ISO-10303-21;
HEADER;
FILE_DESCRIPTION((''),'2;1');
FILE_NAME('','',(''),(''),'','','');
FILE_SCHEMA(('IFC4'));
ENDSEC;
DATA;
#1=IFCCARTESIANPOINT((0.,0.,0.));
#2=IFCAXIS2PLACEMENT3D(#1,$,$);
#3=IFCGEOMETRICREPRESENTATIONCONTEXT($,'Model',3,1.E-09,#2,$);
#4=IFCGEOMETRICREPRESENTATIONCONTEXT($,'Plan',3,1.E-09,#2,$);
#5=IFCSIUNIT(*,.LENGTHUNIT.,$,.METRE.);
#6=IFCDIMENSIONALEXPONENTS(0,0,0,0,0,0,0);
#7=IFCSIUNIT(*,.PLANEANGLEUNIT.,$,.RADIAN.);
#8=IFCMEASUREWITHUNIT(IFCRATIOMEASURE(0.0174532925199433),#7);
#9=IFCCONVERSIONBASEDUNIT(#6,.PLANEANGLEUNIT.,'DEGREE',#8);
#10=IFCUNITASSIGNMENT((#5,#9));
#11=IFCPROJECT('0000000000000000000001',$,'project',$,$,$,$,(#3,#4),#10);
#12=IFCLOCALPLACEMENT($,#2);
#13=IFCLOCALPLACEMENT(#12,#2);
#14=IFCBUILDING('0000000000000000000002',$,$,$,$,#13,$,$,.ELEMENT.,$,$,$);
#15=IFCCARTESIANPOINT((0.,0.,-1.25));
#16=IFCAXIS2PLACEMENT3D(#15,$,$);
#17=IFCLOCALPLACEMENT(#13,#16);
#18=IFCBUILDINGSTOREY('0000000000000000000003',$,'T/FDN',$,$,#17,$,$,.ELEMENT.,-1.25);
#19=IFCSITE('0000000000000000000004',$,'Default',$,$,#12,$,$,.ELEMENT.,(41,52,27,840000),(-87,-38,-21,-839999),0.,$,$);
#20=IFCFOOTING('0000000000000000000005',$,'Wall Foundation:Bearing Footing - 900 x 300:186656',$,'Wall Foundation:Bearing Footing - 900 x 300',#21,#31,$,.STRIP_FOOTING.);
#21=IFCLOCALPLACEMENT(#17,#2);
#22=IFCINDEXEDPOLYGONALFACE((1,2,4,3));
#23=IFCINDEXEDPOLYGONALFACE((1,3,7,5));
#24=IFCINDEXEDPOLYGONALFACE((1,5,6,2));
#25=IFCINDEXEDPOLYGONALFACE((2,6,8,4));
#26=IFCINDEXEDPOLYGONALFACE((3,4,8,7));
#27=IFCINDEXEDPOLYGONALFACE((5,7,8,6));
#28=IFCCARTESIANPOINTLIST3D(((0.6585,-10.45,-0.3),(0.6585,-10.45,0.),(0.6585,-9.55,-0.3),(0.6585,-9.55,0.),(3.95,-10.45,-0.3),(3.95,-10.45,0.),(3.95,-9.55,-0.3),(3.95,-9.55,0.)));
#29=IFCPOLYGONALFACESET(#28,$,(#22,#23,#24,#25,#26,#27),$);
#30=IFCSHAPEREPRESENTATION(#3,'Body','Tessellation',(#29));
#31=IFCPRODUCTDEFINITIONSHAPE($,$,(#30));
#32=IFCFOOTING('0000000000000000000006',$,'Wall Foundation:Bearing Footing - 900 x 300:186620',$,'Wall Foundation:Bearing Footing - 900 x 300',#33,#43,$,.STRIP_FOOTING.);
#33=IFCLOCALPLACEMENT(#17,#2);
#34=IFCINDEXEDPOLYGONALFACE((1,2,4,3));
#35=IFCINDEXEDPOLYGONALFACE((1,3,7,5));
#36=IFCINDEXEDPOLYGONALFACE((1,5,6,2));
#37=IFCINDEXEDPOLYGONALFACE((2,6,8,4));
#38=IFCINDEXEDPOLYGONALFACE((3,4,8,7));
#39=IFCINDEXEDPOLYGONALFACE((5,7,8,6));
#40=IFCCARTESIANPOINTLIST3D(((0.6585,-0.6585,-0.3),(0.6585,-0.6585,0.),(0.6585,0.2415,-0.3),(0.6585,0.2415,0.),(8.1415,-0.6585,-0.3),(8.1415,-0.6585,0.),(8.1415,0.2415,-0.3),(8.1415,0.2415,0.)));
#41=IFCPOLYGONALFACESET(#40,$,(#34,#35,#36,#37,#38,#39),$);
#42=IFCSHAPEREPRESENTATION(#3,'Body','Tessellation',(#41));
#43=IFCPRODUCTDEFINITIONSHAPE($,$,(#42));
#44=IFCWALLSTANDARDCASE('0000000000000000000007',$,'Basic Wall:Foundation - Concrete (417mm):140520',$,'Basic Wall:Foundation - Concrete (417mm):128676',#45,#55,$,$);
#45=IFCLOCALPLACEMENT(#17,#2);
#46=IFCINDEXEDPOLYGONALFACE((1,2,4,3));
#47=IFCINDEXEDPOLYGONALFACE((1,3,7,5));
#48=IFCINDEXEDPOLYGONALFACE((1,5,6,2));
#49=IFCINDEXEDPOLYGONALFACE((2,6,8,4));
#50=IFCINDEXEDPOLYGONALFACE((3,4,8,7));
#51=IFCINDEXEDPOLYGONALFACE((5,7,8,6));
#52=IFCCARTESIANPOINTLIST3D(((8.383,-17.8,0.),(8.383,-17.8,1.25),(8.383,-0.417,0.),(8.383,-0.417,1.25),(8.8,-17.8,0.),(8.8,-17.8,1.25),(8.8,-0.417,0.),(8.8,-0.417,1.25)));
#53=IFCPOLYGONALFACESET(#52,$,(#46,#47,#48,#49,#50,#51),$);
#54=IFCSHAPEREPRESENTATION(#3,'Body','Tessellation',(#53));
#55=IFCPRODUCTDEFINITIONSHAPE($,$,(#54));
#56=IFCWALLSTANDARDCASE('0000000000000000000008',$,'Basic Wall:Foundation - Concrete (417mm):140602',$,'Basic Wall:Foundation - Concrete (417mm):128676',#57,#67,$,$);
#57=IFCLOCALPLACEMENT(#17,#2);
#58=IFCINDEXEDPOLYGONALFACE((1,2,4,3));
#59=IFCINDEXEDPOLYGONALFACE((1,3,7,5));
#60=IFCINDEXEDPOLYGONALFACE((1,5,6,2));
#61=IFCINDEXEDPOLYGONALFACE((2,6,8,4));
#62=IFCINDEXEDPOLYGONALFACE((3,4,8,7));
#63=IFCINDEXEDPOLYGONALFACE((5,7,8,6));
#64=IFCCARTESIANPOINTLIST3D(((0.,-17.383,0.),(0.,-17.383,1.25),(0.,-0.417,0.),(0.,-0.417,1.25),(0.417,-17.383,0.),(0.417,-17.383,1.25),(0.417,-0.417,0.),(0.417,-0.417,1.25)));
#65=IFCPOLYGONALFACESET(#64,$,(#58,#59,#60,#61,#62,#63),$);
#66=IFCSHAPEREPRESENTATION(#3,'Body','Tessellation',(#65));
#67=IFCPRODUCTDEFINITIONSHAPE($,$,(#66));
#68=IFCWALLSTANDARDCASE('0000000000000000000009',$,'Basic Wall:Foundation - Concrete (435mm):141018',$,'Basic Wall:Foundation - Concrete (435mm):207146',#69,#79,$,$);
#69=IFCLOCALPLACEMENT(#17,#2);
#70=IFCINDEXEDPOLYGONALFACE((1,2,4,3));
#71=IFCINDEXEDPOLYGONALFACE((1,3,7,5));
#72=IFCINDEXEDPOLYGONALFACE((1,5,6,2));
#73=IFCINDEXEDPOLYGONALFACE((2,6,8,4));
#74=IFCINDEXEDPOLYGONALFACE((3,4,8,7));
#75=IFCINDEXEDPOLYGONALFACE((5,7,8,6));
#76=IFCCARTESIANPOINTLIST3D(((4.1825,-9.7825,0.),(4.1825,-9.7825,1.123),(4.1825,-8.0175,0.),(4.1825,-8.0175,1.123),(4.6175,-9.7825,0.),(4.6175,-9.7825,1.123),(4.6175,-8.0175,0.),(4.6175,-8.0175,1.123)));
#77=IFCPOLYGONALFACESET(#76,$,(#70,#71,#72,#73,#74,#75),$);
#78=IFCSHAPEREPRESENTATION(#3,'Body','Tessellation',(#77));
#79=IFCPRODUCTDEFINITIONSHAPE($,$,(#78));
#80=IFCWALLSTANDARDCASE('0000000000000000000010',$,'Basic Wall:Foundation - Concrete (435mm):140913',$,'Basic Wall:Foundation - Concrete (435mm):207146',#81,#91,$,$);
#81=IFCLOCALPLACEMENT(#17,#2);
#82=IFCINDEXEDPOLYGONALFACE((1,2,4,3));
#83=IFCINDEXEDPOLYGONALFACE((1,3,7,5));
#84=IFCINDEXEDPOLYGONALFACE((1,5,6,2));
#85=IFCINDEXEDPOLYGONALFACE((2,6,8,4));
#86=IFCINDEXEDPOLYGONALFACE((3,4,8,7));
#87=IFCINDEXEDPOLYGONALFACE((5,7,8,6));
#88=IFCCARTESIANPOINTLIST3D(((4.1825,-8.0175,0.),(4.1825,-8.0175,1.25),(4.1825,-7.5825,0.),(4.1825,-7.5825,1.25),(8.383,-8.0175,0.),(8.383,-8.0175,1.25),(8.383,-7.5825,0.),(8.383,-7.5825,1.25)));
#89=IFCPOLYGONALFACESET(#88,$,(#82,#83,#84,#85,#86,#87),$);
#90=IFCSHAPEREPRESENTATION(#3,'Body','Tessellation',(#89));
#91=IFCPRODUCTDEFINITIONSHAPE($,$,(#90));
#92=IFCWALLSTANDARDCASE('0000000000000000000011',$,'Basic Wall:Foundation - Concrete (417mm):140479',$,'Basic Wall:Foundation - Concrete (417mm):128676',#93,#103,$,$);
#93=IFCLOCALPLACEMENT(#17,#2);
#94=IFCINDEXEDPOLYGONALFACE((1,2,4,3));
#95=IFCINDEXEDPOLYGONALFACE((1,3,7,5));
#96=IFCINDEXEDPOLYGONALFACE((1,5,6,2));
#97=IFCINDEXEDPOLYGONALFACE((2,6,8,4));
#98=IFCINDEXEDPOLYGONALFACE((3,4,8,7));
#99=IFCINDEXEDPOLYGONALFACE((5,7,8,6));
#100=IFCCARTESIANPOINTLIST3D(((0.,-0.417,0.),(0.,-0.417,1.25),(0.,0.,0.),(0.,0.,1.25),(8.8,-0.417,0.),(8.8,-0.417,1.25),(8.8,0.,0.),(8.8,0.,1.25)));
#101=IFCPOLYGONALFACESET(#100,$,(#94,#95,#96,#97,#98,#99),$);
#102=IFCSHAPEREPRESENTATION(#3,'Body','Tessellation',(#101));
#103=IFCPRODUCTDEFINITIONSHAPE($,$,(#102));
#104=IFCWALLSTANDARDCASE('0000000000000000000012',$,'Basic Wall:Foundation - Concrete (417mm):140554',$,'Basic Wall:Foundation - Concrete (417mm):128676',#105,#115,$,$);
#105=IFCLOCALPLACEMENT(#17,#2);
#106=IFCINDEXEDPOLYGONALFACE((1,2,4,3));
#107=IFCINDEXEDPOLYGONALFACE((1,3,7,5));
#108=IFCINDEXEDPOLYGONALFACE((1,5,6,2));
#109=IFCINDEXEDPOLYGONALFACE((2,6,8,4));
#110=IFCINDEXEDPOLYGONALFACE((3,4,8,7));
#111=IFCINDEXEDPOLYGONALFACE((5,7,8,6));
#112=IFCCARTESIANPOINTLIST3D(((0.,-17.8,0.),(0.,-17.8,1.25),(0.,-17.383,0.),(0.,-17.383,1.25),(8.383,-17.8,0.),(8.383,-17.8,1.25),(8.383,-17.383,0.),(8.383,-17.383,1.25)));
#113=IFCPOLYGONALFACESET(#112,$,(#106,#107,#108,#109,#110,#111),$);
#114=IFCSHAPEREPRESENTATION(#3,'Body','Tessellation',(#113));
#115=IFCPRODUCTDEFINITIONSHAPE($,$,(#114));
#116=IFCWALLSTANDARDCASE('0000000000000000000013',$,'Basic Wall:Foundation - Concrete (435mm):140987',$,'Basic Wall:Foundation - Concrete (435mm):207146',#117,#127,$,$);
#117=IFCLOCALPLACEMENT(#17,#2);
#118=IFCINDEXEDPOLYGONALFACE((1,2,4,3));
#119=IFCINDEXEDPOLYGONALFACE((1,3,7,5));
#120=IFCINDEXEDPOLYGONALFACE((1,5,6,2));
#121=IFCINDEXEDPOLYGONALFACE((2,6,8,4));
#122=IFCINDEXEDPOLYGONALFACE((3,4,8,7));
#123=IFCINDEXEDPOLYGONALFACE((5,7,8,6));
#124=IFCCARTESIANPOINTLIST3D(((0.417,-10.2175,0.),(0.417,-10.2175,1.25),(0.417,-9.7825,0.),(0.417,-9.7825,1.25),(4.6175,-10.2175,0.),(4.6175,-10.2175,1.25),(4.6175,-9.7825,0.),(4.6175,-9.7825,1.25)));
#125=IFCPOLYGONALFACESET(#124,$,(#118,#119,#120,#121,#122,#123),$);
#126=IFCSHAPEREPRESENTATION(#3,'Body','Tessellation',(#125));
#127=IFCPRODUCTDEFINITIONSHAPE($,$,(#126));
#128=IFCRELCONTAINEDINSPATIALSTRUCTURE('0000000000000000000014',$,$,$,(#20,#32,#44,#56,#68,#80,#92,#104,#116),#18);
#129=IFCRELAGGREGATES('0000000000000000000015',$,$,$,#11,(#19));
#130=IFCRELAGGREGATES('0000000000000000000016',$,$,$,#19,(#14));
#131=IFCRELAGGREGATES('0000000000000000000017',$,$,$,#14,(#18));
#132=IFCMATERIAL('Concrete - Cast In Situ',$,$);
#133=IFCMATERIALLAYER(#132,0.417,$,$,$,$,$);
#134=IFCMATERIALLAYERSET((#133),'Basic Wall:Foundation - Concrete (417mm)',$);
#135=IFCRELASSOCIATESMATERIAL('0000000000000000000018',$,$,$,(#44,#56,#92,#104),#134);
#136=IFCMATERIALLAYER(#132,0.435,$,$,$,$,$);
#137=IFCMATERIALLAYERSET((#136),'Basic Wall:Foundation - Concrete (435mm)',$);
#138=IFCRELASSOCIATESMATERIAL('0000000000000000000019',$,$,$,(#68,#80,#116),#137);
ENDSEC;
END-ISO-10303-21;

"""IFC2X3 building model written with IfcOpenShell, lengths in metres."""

from ifc_helpers import new_model, entity, si_unit, converted_unit, frame, frame_2d, origin, origin_2d_with_axis, place, context, project, spatial, rectangle, extrude, material, layer, layer_set, layer_usage, element, save


model = new_model("IFC2X3")

# Units and contexts
model_context = context("Model", 3, precision=1e-09, world=origin())
plan_context = context("Plan", 3, precision=1e-09, world=origin())
ifc_project = project(units=[si_unit("LENGTHUNIT", "METRE"), converted_unit("PLANEANGLEUNIT", "DEGREE", entity("IfcRatioMeasure", 0.0174532925199433), si_unit("PLANEANGLEUNIT", "RADIAN"), dimensions=[0, 0, 0, 0, 0, 0, 0])], contexts=[model_context, plan_context])

# Site, building, storey
site_placement = place(None, origin())
site = spatial("IfcSite", under=ifc_project, at=site_placement, Name="Default", CompositionType="ELEMENT", RefLatitude=(41, 52, 27, 840000), RefLongitude=(-87, -38, -21, -839999), RefElevation=0.0)
building_placement = place(site_placement, origin())
building = spatial("IfcBuilding", under=site, at=building_placement, CompositionType="ELEMENT")
storey_placement = place(building_placement, frame((0.0, 0.0, -1.25)))
storey = spatial("IfcBuildingStorey", under=building, at=storey_placement, Name="T/FDN", CompositionType="ELEMENT", Elevation=-1.25)

# Footings
footing_1_placement = place(storey_placement, origin())
element("IfcFooting", 1, at=footing_1_placement, inside=storey, Name="Wall Foundation:Bearing Footing - 900 x 300:186656", ObjectType="Wall Foundation:Bearing Footing - 900 x 300", PredefinedType="STRIP_FOOTING", context=model_context, shape_type="SweptSolid", body=[
    extrude(rectangle(XDim=3.2915, YDim=0.9, at=origin_2d_with_axis()), frame((2.3043, -10.0, -0.3)), (0.0, 0.0, 1.0), 0.3),
])
footing_2_placement = place(storey_placement, origin())
element("IfcFooting", 2, at=footing_2_placement, inside=storey, Name="Wall Foundation:Bearing Footing - 900 x 300:186620", ObjectType="Wall Foundation:Bearing Footing - 900 x 300", PredefinedType="STRIP_FOOTING", context=model_context, shape_type="SweptSolid", body=[
    extrude(rectangle(XDim=7.483, YDim=0.9, at=origin_2d_with_axis()), frame((4.4, -0.2085, -0.3), z_axis=(0.0, 0.0, 1.0), x_axis=(-1.0, 0.0, 0.0)), (0.0, 0.0, 1.0), 0.3),
])

# Walls
ifc_material = material(Name="Concrete - Cast In Situ")
ifc_layer_1 = layer(ifc_material, 0.417)
ifc_layer_set_1 = layer_set([ifc_layer_1], Name="Basic Wall:Foundation - Concrete (417mm)")
ifc_layer_usage_1 = layer_usage(ifc_layer_set_1, "AXIS2", "NEGATIVE", 0.2085)
wall_1_placement = place(storey_placement, frame((8.5915, -0.417, 0.0), z_axis=(0.0, 0.0, 1.0), x_axis=(0.0, -1.0, 0.0)))
element("IfcWallStandardCase", 3, at=wall_1_placement, inside=storey, material=ifc_layer_usage_1, Name="Basic Wall:Foundation - Concrete (417mm):140520", ObjectType="Basic Wall:Foundation - Concrete (417mm):128676", context=model_context, shape_type="SweptSolid", body=[
    extrude(rectangle(XDim=17.383, YDim=0.417, at=frame_2d((8.6915, 0.0), x_axis=(-1.0, 0.0))), origin(), (0.0, 0.0, 1.0), 1.25),
])
wall_2_placement = place(storey_placement, frame((0.2085, -17.383, 0.0), z_axis=(0.0, 0.0, 1.0), x_axis=(0.0, 1.0, 0.0)))
element("IfcWallStandardCase", 4, at=wall_2_placement, inside=storey, material=ifc_layer_usage_1, Name="Basic Wall:Foundation - Concrete (417mm):140602", ObjectType="Basic Wall:Foundation - Concrete (417mm):128676", context=model_context, shape_type="SweptSolid", body=[
    extrude(rectangle(XDim=16.966, YDim=0.417, at=frame_2d((8.483, 0.0), x_axis=(-1.0, 0.0))), origin(), (0.0, 0.0, 1.0), 1.25),
])
ifc_layer_2 = layer(ifc_material, 0.435)
ifc_layer_set_2 = layer_set([ifc_layer_2], Name="Basic Wall:Foundation - Concrete (435mm)")
ifc_layer_usage_2 = layer_usage(ifc_layer_set_2, "AXIS2", "NEGATIVE", 0.2175)
wall_3_placement = place(storey_placement, frame((4.4, -9.7825, 0.0), z_axis=(0.0, 0.0, 1.0), x_axis=(0.0, 1.0, 0.0)))
element("IfcWallStandardCase", 5, at=wall_3_placement, inside=storey, material=ifc_layer_usage_2, Name="Basic Wall:Foundation - Concrete (435mm):141018", ObjectType="Basic Wall:Foundation - Concrete (435mm):207146", context=model_context, shape_type="SweptSolid", body=[
    extrude(rectangle(XDim=1.765, YDim=0.435, at=frame_2d((0.8825, 0.0), x_axis=(-1.0, 0.0))), origin(), (0.0, 0.0, 1.0), 1.123),
])
wall_4_placement = place(storey_placement, frame((8.383, -7.8, 0.0), z_axis=(0.0, 0.0, 1.0), x_axis=(-1.0, 0.0, 0.0)))
element("IfcWallStandardCase", 6, at=wall_4_placement, inside=storey, material=ifc_layer_usage_2, Name="Basic Wall:Foundation - Concrete (435mm):140913", ObjectType="Basic Wall:Foundation - Concrete (435mm):207146", context=model_context, shape_type="SweptSolid", body=[
    extrude(rectangle(XDim=4.2005, YDim=0.435, at=frame_2d((2.1002, 0.0), x_axis=(-1.0, 0.0))), origin(), (0.0, 0.0, 1.0), 1.25),
])
wall_5_placement = place(storey_placement, frame((0.0, -0.2085, 0.0)))
element("IfcWallStandardCase", 7, at=wall_5_placement, inside=storey, material=ifc_layer_usage_1, Name="Basic Wall:Foundation - Concrete (417mm):140479", ObjectType="Basic Wall:Foundation - Concrete (417mm):128676", context=model_context, shape_type="SweptSolid", body=[
    extrude(rectangle(XDim=8.8, YDim=0.417, at=frame_2d((4.4, 0.0), x_axis=(-1.0, 0.0))), origin(), (0.0, 0.0, 1.0), 1.25),
])
wall_6_placement = place(storey_placement, frame((8.383, -17.5915, 0.0), z_axis=(0.0, 0.0, 1.0), x_axis=(-1.0, 0.0, 0.0)))
element("IfcWallStandardCase", 8, at=wall_6_placement, inside=storey, material=ifc_layer_usage_1, Name="Basic Wall:Foundation - Concrete (417mm):140554", ObjectType="Basic Wall:Foundation - Concrete (417mm):128676", context=model_context, shape_type="SweptSolid", body=[
    extrude(rectangle(XDim=8.383, YDim=0.417, at=frame_2d((4.1915, 0.0), x_axis=(-1.0, 0.0))), origin(), (0.0, 0.0, 1.0), 1.25),
])
wall_7_placement = place(storey_placement, frame((0.417, -10.0, 0.0)))
element("IfcWallStandardCase", 9, at=wall_7_placement, inside=storey, material=ifc_layer_usage_2, Name="Basic Wall:Foundation - Concrete (435mm):140987", ObjectType="Basic Wall:Foundation - Concrete (435mm):207146", context=model_context, shape_type="SweptSolid", body=[
    extrude(rectangle(XDim=4.2005, YDim=0.435, at=frame_2d((2.1002, 0.0), x_axis=(-1.0, 0.0))), origin(), (0.0, 0.0, 1.0), 1.25),
])

save(model, "model.ifc")
